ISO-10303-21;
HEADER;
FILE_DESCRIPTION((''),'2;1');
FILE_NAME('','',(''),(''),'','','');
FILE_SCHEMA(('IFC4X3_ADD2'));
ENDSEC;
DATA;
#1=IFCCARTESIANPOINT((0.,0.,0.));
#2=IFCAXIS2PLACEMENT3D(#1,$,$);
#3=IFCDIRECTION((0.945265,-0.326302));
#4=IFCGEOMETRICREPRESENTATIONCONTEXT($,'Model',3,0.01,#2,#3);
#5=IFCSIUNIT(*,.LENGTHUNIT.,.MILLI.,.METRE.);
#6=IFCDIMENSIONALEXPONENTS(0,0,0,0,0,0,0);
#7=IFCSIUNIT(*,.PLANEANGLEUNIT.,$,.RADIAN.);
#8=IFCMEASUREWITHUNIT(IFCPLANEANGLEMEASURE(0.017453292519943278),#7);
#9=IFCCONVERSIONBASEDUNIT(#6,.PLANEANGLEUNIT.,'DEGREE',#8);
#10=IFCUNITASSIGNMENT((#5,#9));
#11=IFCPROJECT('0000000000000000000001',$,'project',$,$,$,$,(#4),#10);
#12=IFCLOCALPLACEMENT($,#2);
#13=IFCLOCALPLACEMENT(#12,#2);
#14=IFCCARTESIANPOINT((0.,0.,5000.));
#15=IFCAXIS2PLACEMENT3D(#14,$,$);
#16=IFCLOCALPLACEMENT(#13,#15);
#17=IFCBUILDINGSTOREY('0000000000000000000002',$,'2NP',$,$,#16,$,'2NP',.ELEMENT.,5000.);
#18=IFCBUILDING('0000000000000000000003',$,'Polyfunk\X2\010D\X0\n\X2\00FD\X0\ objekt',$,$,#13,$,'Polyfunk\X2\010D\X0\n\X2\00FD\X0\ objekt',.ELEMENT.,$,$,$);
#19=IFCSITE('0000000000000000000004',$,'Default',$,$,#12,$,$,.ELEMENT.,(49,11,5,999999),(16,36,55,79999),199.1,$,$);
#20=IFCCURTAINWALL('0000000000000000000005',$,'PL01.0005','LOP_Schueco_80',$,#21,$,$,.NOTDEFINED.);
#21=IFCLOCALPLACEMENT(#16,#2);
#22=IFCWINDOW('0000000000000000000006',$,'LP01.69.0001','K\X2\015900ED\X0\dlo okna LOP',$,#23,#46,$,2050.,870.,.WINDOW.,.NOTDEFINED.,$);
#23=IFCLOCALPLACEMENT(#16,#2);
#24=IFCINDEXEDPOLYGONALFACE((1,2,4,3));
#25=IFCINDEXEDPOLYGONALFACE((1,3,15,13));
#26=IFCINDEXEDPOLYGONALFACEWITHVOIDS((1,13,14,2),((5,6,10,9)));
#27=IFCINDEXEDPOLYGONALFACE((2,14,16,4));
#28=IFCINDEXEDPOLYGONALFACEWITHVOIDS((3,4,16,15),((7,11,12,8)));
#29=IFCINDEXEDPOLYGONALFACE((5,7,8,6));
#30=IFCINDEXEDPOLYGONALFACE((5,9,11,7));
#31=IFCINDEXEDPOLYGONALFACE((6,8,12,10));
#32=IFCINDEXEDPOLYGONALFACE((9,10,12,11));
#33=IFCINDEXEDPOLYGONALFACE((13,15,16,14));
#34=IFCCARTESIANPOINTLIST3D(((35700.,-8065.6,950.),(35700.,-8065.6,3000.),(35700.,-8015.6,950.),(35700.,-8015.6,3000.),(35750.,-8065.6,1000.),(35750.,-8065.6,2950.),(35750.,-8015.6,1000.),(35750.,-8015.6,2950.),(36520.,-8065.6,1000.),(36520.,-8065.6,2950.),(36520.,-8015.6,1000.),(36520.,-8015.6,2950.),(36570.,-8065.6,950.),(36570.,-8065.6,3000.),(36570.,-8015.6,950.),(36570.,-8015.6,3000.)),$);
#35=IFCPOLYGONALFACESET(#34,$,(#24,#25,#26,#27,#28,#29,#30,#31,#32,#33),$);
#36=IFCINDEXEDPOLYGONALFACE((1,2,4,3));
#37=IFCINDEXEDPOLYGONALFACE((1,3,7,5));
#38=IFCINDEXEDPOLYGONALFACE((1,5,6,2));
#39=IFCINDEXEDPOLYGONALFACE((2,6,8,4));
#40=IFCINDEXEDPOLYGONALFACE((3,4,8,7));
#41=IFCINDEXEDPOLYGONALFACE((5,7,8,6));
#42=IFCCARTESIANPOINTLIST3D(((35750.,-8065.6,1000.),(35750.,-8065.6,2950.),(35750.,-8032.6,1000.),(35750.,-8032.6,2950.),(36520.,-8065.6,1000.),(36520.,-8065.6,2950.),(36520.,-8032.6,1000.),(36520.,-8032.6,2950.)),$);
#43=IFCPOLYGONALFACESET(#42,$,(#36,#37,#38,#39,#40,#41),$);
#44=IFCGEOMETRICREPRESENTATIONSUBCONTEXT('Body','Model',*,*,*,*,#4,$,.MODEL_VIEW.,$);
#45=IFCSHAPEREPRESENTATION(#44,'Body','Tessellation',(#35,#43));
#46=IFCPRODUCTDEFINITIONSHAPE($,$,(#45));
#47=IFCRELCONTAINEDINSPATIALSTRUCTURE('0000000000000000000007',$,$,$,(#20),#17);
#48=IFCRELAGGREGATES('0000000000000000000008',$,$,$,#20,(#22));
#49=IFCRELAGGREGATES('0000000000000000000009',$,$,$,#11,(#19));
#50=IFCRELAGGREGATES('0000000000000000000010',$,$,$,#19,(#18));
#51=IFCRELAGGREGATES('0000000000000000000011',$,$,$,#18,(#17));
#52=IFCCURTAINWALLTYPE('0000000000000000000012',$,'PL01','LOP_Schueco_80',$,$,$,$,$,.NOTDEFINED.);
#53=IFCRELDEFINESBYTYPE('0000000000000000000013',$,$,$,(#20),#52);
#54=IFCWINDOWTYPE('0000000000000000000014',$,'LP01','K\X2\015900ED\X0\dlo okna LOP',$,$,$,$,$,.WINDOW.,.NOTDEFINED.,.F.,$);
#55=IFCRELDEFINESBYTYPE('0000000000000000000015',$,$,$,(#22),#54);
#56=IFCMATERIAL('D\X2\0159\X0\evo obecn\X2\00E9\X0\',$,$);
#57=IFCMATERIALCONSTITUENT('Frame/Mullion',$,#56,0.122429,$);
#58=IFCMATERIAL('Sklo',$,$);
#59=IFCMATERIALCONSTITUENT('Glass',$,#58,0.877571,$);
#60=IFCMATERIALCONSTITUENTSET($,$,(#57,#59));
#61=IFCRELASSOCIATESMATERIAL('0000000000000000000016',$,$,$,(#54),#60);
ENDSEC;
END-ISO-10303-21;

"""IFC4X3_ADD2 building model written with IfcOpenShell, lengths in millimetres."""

from ifc_helpers import new_model, entity, si_unit, converted_unit, direction, frame, frame_2d, origin, place, context, subcontext, project, spatial, polyline, rectangle, outline, extrude, source, transform, mapped, material, constituent, constituent_set, type_object, type_shapes, element, aggregate, save


model = new_model("IFC4X3_ADD2")

# Units and contexts
model_context = context("Model", 3, precision=0.01, world=origin(), true_north=direction((0.945265, -0.326302)))
body_context = subcontext(model_context, "Body", "Model", "MODEL_VIEW")
ifc_project = project(units=[si_unit("LENGTHUNIT", "METRE", prefix="MILLI"), converted_unit("PLANEANGLEUNIT", "DEGREE", entity("IfcPlaneAngleMeasure", 0.017453292519943278), si_unit("PLANEANGLEUNIT", "RADIAN"), dimensions=[0, 0, 0, 0, 0, 0, 0])], contexts=[model_context])

# Site, building, storey
site_placement = place(None, origin())
site = spatial("IfcSite", under=ifc_project, at=site_placement, Name="Default", CompositionType="ELEMENT", RefLatitude=(49, 11, 5, 999999), RefLongitude=(16, 36, 55, 79999), RefElevation=199.1)
building_placement = place(site_placement, origin())
building = spatial("IfcBuilding", under=site, at=building_placement, Name="Polyfunkčný objekt", LongName="Polyfunkčný objekt", CompositionType="ELEMENT")
storey_placement = place(building_placement, frame((0.0, 0.0, 5000.0)))
storey = spatial("IfcBuildingStorey", under=building, at=storey_placement, Name="2NP", LongName="2NP", CompositionType="ELEMENT", Elevation=5000.0)

# Curtain wall
curtain_wall_type = type_object("IfcCurtainWallType", Name="PL01", Description="LOP_Schueco_80", PredefinedType="NOTDEFINED")
curtain_wall_placement = place(storey_placement, frame((0.0, 0.0, -5000.0)))
curtain_wall = element("IfcCurtainWall", 1, at=curtain_wall_placement, inside=storey, type_object=curtain_wall_type, Name="PL01.0005", Description="LOP_Schueco_80", PredefinedType="NOTDEFINED")
ifc_material_1 = material(Name="Sklo")

# Window
ifc_material_2 = material(Name="Dřevo obecné")
ifc_constituent_1 = constituent(ifc_material_2, Name="Frame/Mullion", fraction=0.122429)
ifc_constituent_2 = constituent(ifc_material_1, Name="Glass", fraction=0.877571)
ifc_constituent_set = constituent_set(constituents=[ifc_constituent_1, ifc_constituent_2])
window_type = type_object("IfcWindowType", Name="LP01", Description="Křídlo okna LOP", ParameterTakesPrecedence=False, PartitioningType="NOTDEFINED", PredefinedType="WINDOW", material=ifc_constituent_set)
shared_shape_1 = source(origin(), body_context, "Body", "SweptSolid", [
    extrude(outline(polyline([(-1025.0, -435.0), (1025.0, -435.0), (1025.0, 435.0), (-1025.0, 435.0), (-1025.0, -435.0)]), holes=[polyline([(-975.0, -385.0), (-975.0, 385.0), (975.0, 385.0), (975.0, -385.0), (-975.0, -385.0)])]), frame((0.0, 50.0, 1025.0), z_axis=(0.0, -1.0, 0.0), x_axis=(0.0, 0.0, -1.0)), (0.0, 0.0, 1.0), 50.0),
    extrude(rectangle(XDim=770.0, YDim=33.0, at=frame_2d((0.0, 0.0), x_axis=(1.0, 0.0))), frame((0.0, 33.5, 50.0), z_axis=(0.0, 0.0, 1.0), x_axis=(-1.0, 0.0, 0.0)), (0.0, 0.0, 1.0), 1950.0),
])
type_shapes(window_type, [shared_shape_1])
window_placement = place(curtain_wall_placement, frame((36135.0, -8015.6, 5950.0), z_axis=(0.0, 0.0, 1.0), x_axis=(-1.0, 0.0, 0.0)))
window = element("IfcWindow", 2, at=window_placement, type_object=window_type, Name="LP01.69.0001", Description="Křídlo okna LOP", OverallHeight=2050.0, OverallWidth=870.0, PartitioningType="NOTDEFINED", PredefinedType="WINDOW", context=body_context, shape_type="MappedRepresentation", body=[
    mapped(shared_shape_1, transform((0.0, 0.0, 0.0), scale=1.0)),
])
aggregate(curtain_wall, [window])

save(model, "model.ifc")
